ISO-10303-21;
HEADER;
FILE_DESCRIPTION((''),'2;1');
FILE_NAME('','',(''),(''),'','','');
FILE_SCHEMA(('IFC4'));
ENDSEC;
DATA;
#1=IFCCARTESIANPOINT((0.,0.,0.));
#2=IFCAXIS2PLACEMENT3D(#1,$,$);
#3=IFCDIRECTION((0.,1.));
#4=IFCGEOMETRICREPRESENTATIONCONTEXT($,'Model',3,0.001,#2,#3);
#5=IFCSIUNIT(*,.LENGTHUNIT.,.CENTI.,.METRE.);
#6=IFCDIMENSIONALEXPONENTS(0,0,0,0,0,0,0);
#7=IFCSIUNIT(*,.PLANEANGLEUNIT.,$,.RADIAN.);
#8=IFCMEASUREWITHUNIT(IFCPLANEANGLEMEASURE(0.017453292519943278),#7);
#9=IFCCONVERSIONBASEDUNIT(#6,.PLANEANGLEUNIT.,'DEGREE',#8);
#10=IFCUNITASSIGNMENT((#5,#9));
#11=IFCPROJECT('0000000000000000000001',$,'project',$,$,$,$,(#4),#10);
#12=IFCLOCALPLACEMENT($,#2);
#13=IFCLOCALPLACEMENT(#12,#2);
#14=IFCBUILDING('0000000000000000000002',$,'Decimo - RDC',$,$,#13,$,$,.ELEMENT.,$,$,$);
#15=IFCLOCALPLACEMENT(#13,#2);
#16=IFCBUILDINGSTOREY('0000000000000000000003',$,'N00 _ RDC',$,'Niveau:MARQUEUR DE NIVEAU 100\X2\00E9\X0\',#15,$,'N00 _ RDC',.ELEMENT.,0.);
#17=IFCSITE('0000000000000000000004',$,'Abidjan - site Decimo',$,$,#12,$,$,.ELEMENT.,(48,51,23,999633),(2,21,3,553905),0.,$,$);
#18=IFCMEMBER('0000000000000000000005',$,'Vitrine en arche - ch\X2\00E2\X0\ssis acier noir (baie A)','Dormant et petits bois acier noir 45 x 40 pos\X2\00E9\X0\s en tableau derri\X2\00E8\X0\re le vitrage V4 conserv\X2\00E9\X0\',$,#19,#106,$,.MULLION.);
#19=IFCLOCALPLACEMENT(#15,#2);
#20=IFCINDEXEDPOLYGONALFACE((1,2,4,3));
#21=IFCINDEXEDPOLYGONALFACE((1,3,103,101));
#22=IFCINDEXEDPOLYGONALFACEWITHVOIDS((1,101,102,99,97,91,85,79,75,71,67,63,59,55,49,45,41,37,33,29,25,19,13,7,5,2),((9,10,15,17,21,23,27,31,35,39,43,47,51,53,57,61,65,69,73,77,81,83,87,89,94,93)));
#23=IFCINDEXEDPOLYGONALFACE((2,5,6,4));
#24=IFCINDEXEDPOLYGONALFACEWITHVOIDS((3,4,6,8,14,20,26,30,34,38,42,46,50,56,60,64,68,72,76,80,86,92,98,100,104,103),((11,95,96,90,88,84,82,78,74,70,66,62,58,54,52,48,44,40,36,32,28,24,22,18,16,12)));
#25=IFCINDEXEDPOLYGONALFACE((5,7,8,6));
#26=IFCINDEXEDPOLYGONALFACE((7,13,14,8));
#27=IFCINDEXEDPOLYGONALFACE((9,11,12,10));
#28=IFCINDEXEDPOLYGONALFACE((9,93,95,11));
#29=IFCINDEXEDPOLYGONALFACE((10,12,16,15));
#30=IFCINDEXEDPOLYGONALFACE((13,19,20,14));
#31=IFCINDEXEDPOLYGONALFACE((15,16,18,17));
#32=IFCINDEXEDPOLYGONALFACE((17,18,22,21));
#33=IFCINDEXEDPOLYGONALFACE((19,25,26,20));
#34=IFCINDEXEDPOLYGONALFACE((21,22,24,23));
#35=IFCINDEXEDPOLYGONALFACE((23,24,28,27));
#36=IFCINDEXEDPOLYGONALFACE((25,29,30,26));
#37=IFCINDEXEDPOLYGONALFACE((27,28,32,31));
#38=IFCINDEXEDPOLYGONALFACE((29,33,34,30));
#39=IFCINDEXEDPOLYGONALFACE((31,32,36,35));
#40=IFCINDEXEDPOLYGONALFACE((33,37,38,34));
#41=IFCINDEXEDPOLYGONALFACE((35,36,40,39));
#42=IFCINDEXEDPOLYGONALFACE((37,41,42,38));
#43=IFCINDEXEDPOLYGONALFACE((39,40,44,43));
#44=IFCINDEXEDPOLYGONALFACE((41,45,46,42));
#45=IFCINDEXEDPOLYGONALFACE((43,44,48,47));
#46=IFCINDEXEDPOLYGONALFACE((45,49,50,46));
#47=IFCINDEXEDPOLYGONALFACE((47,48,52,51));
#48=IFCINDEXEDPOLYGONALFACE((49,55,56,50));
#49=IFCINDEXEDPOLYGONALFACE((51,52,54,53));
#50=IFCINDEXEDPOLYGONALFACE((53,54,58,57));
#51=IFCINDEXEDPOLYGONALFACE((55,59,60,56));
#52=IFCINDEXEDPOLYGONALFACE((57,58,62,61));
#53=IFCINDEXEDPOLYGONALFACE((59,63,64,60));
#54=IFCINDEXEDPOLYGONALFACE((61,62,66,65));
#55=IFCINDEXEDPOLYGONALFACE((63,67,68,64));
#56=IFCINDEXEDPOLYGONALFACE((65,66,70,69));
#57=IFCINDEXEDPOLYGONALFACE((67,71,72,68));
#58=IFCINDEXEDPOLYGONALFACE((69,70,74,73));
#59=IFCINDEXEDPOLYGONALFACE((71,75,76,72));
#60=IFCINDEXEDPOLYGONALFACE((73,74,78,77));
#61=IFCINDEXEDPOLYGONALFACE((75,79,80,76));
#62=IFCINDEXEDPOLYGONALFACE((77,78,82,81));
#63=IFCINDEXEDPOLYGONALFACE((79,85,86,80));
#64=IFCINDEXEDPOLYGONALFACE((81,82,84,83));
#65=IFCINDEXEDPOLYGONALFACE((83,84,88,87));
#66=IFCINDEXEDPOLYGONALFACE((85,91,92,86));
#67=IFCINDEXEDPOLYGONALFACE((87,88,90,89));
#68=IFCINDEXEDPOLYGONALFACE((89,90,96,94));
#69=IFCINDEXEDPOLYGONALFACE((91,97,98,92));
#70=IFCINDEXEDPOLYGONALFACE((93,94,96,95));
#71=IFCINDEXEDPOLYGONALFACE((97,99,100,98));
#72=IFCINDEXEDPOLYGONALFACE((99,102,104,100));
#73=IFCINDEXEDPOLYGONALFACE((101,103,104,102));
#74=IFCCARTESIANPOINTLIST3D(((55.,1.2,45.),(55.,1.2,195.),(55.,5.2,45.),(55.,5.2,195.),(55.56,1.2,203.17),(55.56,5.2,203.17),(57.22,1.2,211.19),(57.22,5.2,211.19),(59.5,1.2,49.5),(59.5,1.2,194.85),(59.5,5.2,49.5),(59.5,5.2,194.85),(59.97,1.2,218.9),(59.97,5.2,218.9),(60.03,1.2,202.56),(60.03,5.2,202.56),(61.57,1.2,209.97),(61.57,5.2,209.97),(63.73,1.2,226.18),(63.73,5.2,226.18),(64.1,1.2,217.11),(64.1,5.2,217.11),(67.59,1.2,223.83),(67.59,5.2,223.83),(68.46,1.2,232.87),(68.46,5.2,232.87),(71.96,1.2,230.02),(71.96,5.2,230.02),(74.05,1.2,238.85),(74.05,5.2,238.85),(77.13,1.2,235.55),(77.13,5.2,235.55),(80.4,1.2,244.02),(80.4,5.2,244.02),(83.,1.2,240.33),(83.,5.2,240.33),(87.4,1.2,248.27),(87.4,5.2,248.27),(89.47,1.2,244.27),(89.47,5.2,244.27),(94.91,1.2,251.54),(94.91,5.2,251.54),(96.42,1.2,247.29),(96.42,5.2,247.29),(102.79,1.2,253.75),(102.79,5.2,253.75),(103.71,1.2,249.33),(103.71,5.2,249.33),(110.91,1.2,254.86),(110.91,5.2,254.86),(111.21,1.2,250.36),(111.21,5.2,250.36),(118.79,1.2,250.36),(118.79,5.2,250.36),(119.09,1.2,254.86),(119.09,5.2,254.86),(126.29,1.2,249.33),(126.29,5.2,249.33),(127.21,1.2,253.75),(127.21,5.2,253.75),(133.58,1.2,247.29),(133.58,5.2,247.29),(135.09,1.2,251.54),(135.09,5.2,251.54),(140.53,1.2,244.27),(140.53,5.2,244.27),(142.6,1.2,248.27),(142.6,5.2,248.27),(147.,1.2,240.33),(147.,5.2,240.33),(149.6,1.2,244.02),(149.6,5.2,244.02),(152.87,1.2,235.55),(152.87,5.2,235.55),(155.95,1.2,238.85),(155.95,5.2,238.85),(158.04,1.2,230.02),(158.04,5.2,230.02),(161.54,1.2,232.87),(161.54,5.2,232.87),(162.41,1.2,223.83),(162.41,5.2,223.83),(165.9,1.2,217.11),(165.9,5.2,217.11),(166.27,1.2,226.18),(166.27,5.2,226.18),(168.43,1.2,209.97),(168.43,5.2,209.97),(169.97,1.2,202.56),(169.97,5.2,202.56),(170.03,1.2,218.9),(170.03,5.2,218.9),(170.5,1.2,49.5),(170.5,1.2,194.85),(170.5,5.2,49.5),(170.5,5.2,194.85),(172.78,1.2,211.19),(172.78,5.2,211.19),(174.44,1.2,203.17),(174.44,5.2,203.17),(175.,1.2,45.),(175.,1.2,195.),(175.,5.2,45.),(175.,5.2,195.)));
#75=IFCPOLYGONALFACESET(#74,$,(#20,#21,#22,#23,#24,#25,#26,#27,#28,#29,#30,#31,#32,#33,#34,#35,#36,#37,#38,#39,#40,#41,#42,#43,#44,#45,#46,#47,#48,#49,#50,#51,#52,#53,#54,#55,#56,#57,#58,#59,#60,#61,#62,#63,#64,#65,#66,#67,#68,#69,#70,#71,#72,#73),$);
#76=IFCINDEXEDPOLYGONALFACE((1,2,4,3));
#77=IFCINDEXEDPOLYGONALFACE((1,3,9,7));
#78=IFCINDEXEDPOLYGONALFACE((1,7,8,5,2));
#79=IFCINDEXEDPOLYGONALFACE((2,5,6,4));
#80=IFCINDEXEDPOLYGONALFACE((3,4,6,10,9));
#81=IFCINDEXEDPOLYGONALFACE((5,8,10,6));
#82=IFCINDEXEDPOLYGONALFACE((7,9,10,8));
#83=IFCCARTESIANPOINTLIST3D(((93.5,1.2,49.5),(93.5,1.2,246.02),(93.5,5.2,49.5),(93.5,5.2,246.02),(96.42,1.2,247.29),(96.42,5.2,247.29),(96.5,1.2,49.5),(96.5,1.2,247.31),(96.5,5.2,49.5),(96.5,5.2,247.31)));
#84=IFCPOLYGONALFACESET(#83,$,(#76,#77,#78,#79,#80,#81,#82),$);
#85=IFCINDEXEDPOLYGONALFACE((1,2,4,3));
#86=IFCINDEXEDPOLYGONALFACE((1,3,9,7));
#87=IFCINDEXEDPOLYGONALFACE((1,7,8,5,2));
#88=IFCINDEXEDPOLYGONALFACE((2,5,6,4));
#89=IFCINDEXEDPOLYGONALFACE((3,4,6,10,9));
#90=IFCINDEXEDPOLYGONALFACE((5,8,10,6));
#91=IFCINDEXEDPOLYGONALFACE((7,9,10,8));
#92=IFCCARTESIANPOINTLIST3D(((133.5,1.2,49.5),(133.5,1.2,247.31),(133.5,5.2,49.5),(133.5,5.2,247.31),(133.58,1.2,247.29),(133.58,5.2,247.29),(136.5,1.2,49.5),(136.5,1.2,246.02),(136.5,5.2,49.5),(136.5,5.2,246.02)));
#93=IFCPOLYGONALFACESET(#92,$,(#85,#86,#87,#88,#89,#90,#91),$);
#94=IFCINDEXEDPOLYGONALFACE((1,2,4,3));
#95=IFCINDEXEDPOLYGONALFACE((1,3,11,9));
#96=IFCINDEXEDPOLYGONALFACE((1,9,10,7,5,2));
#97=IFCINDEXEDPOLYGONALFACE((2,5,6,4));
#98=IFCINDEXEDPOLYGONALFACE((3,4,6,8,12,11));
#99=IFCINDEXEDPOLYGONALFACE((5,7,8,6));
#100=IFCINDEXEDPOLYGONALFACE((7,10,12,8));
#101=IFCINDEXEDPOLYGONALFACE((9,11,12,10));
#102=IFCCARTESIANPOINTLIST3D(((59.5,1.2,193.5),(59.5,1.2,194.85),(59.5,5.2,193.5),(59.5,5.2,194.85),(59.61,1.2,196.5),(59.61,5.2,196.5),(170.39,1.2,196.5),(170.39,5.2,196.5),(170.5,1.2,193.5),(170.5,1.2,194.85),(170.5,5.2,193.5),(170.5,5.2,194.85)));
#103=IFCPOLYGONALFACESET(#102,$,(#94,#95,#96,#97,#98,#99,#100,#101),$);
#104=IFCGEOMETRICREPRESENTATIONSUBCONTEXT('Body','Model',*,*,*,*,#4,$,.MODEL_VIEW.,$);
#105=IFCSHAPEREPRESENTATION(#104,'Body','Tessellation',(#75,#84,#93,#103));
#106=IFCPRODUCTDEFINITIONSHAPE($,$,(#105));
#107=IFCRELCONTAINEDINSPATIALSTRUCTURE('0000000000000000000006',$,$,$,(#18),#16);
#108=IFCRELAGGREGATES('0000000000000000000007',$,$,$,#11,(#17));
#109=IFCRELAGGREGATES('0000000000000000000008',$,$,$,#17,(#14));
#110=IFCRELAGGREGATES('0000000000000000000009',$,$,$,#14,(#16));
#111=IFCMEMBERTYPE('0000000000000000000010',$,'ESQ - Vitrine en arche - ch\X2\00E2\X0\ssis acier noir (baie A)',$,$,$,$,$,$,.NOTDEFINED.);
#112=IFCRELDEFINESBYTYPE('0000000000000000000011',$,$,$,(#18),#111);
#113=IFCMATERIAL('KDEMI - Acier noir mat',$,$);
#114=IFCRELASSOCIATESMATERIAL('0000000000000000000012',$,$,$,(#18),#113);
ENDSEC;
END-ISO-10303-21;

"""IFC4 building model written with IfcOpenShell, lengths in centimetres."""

from ifc_helpers import new_model, entity, si_unit, converted_unit, direction, frame, origin, origin_with_axes, place, context, subcontext, project, spatial, polyline, outline, extrude, material, type_object, element, save


model = new_model("IFC4")

# Units and contexts
model_context = context("Model", 3, precision=0.001, world=origin(), true_north=direction((0.0, 1.0)))
body_context = subcontext(model_context, "Body", "Model", "MODEL_VIEW")
ifc_project = project(units=[si_unit("LENGTHUNIT", "METRE", prefix="CENTI"), converted_unit("PLANEANGLEUNIT", "DEGREE", entity("IfcPlaneAngleMeasure", 0.017453292519943278), si_unit("PLANEANGLEUNIT", "RADIAN"), dimensions=[0, 0, 0, 0, 0, 0, 0])], contexts=[model_context])

# Site, building, storey
site_placement = place(None, origin())
site = spatial("IfcSite", under=ifc_project, at=site_placement, Name="Abidjan - site Decimo", CompositionType="ELEMENT", RefLatitude=(48, 51, 23, 999633), RefLongitude=(2, 21, 3, 553905), RefElevation=0.0)
building_placement = place(site_placement, origin())
building = spatial("IfcBuilding", under=site, at=building_placement, Name="Decimo - RDC", CompositionType="ELEMENT")
storey_placement = place(building_placement, origin())
storey = spatial("IfcBuildingStorey", under=building, at=storey_placement, Name="N00 _ RDC", ObjectType="Niveau:MARQUEUR DE NIVEAU 100é", LongName="N00 _ RDC", CompositionType="ELEMENT", Elevation=0.0)

# Member
ifc_material_1 = material(Name="KDEMI - Acier noir mat")
member_type_1 = type_object("IfcMemberType", Name="ESQ - Vitrine en arche - châssis acier noir (baie A)", PredefinedType="NOTDEFINED")
member_1_placement = place(storey_placement, origin_with_axes())
element("IfcMember", 1, at=member_1_placement, inside=storey, type_object=member_type_1, material=ifc_material_1, Name="Vitrine en arche - châssis acier noir (baie A)", Description="Dormant et petits bois acier noir 45 x 40 posés en tableau derrière le vitrage V4 conservé", PredefinedType="MULLION", context=body_context, shape_type="SweptSolid", body=[
    extrude(outline(polyline([(55.0, 195.0), (55.56, 203.17), (57.22, 211.19), (59.97, 218.9), (63.73, 226.18), (68.46, 232.87), (74.05, 238.85), (80.4, 244.02), (87.4, 248.27), (94.91, 251.54), (102.79, 253.75), (110.91, 254.86), (119.09, 254.86), (127.21, 253.75), (135.09, 251.54), (142.6, 248.27), (149.6, 244.02), (155.95, 238.85), (161.54, 232.87), (166.27, 226.18), (170.03, 218.9), (172.78, 211.19), (174.44, 203.17), (175.0, 195.0), (175.0, 45.0), (55.0, 45.0), (55.0, 195.0)]), holes=[polyline([(170.5, 49.5), (170.5, 194.85), (169.97, 202.56), (168.43, 209.97), (165.9, 217.11), (162.41, 223.83), (158.04, 230.02), (152.87, 235.55), (147.0, 240.33), (140.53, 244.27), (133.58, 247.29), (126.29, 249.33), (118.79, 250.36), (111.21, 250.36), (103.71, 249.33), (96.42, 247.29), (89.47, 244.27), (83.0, 240.33), (77.13, 235.55), (71.96, 230.02), (67.59, 223.83), (64.1, 217.11), (61.57, 209.97), (60.03, 202.56), (59.5, 194.85), (59.5, 49.5), (170.5, 49.5)])]), frame((0.0, 5.2, 0.0), z_axis=(0.0, -1.0, 0.0), x_axis=(1.0, 0.0, 0.0)), (0.0, 0.0, 1.0), 4.0),
    extrude(outline(polyline([(96.5, 49.5), (93.5, 49.5), (93.5, 246.02), (96.42, 247.29), (96.5, 247.31), (96.5, 49.5)])), frame((0.0, 5.2, 0.0), z_axis=(0.0, -1.0, 0.0), x_axis=(1.0, 0.0, 0.0)), (0.0, 0.0, 1.0), 4.0),
    extrude(outline(polyline([(136.5, 49.5), (133.5, 49.5), (133.5, 247.31), (133.58, 247.29), (136.5, 246.02), (136.5, 49.5)])), frame((0.0, 5.2, 0.0), z_axis=(0.0, -1.0, 0.0), x_axis=(1.0, 0.0, 0.0)), (0.0, 0.0, 1.0), 4.0),
    extrude(outline(polyline([(170.39, 196.5), (170.5, 194.85), (170.5, 193.5), (59.5, 193.5), (59.5, 194.85), (59.61, 196.5), (170.39, 196.5)])), frame((0.0, 5.2, 0.0), z_axis=(0.0, -1.0, 0.0), x_axis=(1.0, 0.0, 0.0)), (0.0, 0.0, 1.0), 4.0),
])

save(model, "model.ifc")
